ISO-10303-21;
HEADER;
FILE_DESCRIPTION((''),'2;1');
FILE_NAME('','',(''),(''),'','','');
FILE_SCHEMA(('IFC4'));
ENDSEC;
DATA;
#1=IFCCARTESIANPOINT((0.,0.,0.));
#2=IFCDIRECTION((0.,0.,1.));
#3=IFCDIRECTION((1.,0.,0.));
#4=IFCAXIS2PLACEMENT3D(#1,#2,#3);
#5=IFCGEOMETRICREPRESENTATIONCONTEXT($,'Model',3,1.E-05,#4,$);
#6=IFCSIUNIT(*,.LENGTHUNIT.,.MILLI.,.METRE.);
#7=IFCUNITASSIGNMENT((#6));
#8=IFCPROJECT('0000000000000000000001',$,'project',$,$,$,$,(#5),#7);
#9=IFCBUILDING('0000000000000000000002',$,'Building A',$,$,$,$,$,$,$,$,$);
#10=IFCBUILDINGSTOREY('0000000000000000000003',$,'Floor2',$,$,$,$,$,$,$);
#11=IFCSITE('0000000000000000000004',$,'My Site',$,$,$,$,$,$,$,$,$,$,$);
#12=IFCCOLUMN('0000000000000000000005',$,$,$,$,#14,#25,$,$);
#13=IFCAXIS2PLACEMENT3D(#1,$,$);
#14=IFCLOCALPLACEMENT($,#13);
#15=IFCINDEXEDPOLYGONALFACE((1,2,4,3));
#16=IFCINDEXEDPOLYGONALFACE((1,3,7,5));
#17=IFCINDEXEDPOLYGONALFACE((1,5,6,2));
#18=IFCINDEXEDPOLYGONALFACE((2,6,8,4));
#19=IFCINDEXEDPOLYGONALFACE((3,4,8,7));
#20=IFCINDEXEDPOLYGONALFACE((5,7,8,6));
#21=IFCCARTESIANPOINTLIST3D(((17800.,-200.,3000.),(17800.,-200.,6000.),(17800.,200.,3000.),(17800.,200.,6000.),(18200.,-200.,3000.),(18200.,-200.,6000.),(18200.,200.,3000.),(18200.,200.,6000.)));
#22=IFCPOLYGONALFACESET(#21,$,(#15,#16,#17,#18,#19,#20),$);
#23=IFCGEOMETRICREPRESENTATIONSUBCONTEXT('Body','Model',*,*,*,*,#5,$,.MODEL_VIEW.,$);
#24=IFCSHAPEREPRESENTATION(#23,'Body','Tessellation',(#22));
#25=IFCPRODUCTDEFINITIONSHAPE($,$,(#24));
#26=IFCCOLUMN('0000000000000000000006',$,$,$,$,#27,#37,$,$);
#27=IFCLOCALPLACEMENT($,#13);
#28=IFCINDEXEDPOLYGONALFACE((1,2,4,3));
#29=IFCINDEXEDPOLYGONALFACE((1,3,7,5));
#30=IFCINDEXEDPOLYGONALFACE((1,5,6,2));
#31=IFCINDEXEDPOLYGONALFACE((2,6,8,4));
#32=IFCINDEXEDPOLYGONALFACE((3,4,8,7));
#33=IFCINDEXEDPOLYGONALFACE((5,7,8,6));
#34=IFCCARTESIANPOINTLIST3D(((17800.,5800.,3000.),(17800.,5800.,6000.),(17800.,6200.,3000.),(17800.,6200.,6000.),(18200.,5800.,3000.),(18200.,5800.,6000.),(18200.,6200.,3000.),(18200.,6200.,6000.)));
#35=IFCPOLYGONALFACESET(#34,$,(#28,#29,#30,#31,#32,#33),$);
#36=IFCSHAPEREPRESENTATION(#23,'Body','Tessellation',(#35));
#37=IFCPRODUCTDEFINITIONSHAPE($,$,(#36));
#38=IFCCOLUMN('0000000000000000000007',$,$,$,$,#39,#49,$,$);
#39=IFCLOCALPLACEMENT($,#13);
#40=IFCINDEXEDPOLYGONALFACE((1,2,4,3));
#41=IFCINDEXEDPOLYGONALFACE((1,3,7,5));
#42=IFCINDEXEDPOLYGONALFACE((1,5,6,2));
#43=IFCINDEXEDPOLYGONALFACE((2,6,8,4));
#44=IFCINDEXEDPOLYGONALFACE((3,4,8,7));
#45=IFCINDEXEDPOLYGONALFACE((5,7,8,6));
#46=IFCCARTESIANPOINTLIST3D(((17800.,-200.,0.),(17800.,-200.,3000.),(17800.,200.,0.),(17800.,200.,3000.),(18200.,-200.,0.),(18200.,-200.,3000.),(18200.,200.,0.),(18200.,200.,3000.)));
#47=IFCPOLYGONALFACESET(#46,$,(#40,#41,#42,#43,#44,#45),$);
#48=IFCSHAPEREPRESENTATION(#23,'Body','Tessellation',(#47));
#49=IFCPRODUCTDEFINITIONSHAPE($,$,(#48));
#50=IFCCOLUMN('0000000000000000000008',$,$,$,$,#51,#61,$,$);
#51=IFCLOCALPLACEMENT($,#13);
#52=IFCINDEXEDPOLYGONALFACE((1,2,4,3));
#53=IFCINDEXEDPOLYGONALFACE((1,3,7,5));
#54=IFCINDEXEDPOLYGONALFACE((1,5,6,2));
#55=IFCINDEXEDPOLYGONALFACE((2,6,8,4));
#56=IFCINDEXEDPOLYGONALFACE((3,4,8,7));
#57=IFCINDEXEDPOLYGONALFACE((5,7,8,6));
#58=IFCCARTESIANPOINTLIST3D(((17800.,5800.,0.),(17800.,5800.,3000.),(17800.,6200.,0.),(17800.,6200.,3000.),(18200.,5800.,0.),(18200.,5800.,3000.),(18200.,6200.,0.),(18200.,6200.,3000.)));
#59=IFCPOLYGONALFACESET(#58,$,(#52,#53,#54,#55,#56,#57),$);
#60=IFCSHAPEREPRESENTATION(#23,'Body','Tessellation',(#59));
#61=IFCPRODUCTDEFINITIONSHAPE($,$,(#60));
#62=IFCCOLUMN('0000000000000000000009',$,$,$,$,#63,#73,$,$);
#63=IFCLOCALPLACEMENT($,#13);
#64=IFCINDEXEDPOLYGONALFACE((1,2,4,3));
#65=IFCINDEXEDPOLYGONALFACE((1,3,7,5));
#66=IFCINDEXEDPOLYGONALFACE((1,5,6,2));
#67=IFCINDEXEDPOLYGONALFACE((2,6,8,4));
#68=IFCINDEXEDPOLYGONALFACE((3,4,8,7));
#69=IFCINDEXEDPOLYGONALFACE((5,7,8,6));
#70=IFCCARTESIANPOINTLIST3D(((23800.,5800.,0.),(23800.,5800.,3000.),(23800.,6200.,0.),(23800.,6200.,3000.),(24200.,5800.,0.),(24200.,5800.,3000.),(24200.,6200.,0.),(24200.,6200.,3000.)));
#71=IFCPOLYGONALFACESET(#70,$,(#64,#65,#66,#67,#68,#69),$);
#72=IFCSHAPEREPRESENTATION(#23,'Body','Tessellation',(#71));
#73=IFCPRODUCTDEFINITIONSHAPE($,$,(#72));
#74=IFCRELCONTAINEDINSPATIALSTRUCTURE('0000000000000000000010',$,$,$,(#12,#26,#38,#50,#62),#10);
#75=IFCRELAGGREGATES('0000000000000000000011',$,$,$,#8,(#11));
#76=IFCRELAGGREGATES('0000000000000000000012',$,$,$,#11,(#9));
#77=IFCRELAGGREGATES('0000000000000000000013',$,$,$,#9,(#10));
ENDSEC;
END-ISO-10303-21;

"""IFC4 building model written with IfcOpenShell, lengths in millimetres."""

from ifc_helpers import new_model, si_unit, frame, origin_with_axes, place, context, subcontext, project, spatial, line, indexed_curve, outline, extrude, element, save


model = new_model("IFC4")

# Units and contexts
model_context = context("Model", 3, precision=1e-05, world=origin_with_axes())
body_context = subcontext(model_context, "Body", "Model", "MODEL_VIEW")
ifc_project = project(units=[si_unit("LENGTHUNIT", "METRE", prefix="MILLI")], contexts=[model_context])

# Site, building, storey
site = spatial("IfcSite", under=ifc_project, Name="My Site")
building = spatial("IfcBuilding", under=site, Name="Building A")
storey = spatial("IfcBuildingStorey", under=building, Name="Floor2")

# Columns
for number, where, z_axis, x_axis in (
    (1, (18000.0, 0.0, 3000.0), (0.0, 0.0, 1.0), (1.0, 0.0, 0.0)),
    (2, (18000.0, 6000.0, 3000.0), (0.0, 0.0, 1.0), (1.0, 0.0, 0.0)),
    (3, (18000.0, 0.0, 0.0), (0.0, 0.0, 1.0), (1.0, 0.0, 0.0)),
    (4, (18000.0, 6000.0, 0.0), (0.0, 0.0, 1.0), (1.0, 0.0, 0.0)),
    (5, (24000.0, 6000.0, 0.0), (0.0, 0.0, 1.0), (1.0, 0.0, 0.0)),
):
    element("IfcColumn", number, at=place(None, frame(where, z_axis=z_axis, x_axis=x_axis)), inside=storey, context=body_context, shape_type="SweptSolid", body=[
        extrude(outline(indexed_curve([(-200.0, -200.0), (200.0, -200.0), (200.0, 200.0), (-200.0, 200.0)], segments=[line(1, 2, 3, 4, 1)])), origin_with_axes(), (0.0, 0.0, 1.0), 3000.0),
    ])

save(model, "model.ifc")
